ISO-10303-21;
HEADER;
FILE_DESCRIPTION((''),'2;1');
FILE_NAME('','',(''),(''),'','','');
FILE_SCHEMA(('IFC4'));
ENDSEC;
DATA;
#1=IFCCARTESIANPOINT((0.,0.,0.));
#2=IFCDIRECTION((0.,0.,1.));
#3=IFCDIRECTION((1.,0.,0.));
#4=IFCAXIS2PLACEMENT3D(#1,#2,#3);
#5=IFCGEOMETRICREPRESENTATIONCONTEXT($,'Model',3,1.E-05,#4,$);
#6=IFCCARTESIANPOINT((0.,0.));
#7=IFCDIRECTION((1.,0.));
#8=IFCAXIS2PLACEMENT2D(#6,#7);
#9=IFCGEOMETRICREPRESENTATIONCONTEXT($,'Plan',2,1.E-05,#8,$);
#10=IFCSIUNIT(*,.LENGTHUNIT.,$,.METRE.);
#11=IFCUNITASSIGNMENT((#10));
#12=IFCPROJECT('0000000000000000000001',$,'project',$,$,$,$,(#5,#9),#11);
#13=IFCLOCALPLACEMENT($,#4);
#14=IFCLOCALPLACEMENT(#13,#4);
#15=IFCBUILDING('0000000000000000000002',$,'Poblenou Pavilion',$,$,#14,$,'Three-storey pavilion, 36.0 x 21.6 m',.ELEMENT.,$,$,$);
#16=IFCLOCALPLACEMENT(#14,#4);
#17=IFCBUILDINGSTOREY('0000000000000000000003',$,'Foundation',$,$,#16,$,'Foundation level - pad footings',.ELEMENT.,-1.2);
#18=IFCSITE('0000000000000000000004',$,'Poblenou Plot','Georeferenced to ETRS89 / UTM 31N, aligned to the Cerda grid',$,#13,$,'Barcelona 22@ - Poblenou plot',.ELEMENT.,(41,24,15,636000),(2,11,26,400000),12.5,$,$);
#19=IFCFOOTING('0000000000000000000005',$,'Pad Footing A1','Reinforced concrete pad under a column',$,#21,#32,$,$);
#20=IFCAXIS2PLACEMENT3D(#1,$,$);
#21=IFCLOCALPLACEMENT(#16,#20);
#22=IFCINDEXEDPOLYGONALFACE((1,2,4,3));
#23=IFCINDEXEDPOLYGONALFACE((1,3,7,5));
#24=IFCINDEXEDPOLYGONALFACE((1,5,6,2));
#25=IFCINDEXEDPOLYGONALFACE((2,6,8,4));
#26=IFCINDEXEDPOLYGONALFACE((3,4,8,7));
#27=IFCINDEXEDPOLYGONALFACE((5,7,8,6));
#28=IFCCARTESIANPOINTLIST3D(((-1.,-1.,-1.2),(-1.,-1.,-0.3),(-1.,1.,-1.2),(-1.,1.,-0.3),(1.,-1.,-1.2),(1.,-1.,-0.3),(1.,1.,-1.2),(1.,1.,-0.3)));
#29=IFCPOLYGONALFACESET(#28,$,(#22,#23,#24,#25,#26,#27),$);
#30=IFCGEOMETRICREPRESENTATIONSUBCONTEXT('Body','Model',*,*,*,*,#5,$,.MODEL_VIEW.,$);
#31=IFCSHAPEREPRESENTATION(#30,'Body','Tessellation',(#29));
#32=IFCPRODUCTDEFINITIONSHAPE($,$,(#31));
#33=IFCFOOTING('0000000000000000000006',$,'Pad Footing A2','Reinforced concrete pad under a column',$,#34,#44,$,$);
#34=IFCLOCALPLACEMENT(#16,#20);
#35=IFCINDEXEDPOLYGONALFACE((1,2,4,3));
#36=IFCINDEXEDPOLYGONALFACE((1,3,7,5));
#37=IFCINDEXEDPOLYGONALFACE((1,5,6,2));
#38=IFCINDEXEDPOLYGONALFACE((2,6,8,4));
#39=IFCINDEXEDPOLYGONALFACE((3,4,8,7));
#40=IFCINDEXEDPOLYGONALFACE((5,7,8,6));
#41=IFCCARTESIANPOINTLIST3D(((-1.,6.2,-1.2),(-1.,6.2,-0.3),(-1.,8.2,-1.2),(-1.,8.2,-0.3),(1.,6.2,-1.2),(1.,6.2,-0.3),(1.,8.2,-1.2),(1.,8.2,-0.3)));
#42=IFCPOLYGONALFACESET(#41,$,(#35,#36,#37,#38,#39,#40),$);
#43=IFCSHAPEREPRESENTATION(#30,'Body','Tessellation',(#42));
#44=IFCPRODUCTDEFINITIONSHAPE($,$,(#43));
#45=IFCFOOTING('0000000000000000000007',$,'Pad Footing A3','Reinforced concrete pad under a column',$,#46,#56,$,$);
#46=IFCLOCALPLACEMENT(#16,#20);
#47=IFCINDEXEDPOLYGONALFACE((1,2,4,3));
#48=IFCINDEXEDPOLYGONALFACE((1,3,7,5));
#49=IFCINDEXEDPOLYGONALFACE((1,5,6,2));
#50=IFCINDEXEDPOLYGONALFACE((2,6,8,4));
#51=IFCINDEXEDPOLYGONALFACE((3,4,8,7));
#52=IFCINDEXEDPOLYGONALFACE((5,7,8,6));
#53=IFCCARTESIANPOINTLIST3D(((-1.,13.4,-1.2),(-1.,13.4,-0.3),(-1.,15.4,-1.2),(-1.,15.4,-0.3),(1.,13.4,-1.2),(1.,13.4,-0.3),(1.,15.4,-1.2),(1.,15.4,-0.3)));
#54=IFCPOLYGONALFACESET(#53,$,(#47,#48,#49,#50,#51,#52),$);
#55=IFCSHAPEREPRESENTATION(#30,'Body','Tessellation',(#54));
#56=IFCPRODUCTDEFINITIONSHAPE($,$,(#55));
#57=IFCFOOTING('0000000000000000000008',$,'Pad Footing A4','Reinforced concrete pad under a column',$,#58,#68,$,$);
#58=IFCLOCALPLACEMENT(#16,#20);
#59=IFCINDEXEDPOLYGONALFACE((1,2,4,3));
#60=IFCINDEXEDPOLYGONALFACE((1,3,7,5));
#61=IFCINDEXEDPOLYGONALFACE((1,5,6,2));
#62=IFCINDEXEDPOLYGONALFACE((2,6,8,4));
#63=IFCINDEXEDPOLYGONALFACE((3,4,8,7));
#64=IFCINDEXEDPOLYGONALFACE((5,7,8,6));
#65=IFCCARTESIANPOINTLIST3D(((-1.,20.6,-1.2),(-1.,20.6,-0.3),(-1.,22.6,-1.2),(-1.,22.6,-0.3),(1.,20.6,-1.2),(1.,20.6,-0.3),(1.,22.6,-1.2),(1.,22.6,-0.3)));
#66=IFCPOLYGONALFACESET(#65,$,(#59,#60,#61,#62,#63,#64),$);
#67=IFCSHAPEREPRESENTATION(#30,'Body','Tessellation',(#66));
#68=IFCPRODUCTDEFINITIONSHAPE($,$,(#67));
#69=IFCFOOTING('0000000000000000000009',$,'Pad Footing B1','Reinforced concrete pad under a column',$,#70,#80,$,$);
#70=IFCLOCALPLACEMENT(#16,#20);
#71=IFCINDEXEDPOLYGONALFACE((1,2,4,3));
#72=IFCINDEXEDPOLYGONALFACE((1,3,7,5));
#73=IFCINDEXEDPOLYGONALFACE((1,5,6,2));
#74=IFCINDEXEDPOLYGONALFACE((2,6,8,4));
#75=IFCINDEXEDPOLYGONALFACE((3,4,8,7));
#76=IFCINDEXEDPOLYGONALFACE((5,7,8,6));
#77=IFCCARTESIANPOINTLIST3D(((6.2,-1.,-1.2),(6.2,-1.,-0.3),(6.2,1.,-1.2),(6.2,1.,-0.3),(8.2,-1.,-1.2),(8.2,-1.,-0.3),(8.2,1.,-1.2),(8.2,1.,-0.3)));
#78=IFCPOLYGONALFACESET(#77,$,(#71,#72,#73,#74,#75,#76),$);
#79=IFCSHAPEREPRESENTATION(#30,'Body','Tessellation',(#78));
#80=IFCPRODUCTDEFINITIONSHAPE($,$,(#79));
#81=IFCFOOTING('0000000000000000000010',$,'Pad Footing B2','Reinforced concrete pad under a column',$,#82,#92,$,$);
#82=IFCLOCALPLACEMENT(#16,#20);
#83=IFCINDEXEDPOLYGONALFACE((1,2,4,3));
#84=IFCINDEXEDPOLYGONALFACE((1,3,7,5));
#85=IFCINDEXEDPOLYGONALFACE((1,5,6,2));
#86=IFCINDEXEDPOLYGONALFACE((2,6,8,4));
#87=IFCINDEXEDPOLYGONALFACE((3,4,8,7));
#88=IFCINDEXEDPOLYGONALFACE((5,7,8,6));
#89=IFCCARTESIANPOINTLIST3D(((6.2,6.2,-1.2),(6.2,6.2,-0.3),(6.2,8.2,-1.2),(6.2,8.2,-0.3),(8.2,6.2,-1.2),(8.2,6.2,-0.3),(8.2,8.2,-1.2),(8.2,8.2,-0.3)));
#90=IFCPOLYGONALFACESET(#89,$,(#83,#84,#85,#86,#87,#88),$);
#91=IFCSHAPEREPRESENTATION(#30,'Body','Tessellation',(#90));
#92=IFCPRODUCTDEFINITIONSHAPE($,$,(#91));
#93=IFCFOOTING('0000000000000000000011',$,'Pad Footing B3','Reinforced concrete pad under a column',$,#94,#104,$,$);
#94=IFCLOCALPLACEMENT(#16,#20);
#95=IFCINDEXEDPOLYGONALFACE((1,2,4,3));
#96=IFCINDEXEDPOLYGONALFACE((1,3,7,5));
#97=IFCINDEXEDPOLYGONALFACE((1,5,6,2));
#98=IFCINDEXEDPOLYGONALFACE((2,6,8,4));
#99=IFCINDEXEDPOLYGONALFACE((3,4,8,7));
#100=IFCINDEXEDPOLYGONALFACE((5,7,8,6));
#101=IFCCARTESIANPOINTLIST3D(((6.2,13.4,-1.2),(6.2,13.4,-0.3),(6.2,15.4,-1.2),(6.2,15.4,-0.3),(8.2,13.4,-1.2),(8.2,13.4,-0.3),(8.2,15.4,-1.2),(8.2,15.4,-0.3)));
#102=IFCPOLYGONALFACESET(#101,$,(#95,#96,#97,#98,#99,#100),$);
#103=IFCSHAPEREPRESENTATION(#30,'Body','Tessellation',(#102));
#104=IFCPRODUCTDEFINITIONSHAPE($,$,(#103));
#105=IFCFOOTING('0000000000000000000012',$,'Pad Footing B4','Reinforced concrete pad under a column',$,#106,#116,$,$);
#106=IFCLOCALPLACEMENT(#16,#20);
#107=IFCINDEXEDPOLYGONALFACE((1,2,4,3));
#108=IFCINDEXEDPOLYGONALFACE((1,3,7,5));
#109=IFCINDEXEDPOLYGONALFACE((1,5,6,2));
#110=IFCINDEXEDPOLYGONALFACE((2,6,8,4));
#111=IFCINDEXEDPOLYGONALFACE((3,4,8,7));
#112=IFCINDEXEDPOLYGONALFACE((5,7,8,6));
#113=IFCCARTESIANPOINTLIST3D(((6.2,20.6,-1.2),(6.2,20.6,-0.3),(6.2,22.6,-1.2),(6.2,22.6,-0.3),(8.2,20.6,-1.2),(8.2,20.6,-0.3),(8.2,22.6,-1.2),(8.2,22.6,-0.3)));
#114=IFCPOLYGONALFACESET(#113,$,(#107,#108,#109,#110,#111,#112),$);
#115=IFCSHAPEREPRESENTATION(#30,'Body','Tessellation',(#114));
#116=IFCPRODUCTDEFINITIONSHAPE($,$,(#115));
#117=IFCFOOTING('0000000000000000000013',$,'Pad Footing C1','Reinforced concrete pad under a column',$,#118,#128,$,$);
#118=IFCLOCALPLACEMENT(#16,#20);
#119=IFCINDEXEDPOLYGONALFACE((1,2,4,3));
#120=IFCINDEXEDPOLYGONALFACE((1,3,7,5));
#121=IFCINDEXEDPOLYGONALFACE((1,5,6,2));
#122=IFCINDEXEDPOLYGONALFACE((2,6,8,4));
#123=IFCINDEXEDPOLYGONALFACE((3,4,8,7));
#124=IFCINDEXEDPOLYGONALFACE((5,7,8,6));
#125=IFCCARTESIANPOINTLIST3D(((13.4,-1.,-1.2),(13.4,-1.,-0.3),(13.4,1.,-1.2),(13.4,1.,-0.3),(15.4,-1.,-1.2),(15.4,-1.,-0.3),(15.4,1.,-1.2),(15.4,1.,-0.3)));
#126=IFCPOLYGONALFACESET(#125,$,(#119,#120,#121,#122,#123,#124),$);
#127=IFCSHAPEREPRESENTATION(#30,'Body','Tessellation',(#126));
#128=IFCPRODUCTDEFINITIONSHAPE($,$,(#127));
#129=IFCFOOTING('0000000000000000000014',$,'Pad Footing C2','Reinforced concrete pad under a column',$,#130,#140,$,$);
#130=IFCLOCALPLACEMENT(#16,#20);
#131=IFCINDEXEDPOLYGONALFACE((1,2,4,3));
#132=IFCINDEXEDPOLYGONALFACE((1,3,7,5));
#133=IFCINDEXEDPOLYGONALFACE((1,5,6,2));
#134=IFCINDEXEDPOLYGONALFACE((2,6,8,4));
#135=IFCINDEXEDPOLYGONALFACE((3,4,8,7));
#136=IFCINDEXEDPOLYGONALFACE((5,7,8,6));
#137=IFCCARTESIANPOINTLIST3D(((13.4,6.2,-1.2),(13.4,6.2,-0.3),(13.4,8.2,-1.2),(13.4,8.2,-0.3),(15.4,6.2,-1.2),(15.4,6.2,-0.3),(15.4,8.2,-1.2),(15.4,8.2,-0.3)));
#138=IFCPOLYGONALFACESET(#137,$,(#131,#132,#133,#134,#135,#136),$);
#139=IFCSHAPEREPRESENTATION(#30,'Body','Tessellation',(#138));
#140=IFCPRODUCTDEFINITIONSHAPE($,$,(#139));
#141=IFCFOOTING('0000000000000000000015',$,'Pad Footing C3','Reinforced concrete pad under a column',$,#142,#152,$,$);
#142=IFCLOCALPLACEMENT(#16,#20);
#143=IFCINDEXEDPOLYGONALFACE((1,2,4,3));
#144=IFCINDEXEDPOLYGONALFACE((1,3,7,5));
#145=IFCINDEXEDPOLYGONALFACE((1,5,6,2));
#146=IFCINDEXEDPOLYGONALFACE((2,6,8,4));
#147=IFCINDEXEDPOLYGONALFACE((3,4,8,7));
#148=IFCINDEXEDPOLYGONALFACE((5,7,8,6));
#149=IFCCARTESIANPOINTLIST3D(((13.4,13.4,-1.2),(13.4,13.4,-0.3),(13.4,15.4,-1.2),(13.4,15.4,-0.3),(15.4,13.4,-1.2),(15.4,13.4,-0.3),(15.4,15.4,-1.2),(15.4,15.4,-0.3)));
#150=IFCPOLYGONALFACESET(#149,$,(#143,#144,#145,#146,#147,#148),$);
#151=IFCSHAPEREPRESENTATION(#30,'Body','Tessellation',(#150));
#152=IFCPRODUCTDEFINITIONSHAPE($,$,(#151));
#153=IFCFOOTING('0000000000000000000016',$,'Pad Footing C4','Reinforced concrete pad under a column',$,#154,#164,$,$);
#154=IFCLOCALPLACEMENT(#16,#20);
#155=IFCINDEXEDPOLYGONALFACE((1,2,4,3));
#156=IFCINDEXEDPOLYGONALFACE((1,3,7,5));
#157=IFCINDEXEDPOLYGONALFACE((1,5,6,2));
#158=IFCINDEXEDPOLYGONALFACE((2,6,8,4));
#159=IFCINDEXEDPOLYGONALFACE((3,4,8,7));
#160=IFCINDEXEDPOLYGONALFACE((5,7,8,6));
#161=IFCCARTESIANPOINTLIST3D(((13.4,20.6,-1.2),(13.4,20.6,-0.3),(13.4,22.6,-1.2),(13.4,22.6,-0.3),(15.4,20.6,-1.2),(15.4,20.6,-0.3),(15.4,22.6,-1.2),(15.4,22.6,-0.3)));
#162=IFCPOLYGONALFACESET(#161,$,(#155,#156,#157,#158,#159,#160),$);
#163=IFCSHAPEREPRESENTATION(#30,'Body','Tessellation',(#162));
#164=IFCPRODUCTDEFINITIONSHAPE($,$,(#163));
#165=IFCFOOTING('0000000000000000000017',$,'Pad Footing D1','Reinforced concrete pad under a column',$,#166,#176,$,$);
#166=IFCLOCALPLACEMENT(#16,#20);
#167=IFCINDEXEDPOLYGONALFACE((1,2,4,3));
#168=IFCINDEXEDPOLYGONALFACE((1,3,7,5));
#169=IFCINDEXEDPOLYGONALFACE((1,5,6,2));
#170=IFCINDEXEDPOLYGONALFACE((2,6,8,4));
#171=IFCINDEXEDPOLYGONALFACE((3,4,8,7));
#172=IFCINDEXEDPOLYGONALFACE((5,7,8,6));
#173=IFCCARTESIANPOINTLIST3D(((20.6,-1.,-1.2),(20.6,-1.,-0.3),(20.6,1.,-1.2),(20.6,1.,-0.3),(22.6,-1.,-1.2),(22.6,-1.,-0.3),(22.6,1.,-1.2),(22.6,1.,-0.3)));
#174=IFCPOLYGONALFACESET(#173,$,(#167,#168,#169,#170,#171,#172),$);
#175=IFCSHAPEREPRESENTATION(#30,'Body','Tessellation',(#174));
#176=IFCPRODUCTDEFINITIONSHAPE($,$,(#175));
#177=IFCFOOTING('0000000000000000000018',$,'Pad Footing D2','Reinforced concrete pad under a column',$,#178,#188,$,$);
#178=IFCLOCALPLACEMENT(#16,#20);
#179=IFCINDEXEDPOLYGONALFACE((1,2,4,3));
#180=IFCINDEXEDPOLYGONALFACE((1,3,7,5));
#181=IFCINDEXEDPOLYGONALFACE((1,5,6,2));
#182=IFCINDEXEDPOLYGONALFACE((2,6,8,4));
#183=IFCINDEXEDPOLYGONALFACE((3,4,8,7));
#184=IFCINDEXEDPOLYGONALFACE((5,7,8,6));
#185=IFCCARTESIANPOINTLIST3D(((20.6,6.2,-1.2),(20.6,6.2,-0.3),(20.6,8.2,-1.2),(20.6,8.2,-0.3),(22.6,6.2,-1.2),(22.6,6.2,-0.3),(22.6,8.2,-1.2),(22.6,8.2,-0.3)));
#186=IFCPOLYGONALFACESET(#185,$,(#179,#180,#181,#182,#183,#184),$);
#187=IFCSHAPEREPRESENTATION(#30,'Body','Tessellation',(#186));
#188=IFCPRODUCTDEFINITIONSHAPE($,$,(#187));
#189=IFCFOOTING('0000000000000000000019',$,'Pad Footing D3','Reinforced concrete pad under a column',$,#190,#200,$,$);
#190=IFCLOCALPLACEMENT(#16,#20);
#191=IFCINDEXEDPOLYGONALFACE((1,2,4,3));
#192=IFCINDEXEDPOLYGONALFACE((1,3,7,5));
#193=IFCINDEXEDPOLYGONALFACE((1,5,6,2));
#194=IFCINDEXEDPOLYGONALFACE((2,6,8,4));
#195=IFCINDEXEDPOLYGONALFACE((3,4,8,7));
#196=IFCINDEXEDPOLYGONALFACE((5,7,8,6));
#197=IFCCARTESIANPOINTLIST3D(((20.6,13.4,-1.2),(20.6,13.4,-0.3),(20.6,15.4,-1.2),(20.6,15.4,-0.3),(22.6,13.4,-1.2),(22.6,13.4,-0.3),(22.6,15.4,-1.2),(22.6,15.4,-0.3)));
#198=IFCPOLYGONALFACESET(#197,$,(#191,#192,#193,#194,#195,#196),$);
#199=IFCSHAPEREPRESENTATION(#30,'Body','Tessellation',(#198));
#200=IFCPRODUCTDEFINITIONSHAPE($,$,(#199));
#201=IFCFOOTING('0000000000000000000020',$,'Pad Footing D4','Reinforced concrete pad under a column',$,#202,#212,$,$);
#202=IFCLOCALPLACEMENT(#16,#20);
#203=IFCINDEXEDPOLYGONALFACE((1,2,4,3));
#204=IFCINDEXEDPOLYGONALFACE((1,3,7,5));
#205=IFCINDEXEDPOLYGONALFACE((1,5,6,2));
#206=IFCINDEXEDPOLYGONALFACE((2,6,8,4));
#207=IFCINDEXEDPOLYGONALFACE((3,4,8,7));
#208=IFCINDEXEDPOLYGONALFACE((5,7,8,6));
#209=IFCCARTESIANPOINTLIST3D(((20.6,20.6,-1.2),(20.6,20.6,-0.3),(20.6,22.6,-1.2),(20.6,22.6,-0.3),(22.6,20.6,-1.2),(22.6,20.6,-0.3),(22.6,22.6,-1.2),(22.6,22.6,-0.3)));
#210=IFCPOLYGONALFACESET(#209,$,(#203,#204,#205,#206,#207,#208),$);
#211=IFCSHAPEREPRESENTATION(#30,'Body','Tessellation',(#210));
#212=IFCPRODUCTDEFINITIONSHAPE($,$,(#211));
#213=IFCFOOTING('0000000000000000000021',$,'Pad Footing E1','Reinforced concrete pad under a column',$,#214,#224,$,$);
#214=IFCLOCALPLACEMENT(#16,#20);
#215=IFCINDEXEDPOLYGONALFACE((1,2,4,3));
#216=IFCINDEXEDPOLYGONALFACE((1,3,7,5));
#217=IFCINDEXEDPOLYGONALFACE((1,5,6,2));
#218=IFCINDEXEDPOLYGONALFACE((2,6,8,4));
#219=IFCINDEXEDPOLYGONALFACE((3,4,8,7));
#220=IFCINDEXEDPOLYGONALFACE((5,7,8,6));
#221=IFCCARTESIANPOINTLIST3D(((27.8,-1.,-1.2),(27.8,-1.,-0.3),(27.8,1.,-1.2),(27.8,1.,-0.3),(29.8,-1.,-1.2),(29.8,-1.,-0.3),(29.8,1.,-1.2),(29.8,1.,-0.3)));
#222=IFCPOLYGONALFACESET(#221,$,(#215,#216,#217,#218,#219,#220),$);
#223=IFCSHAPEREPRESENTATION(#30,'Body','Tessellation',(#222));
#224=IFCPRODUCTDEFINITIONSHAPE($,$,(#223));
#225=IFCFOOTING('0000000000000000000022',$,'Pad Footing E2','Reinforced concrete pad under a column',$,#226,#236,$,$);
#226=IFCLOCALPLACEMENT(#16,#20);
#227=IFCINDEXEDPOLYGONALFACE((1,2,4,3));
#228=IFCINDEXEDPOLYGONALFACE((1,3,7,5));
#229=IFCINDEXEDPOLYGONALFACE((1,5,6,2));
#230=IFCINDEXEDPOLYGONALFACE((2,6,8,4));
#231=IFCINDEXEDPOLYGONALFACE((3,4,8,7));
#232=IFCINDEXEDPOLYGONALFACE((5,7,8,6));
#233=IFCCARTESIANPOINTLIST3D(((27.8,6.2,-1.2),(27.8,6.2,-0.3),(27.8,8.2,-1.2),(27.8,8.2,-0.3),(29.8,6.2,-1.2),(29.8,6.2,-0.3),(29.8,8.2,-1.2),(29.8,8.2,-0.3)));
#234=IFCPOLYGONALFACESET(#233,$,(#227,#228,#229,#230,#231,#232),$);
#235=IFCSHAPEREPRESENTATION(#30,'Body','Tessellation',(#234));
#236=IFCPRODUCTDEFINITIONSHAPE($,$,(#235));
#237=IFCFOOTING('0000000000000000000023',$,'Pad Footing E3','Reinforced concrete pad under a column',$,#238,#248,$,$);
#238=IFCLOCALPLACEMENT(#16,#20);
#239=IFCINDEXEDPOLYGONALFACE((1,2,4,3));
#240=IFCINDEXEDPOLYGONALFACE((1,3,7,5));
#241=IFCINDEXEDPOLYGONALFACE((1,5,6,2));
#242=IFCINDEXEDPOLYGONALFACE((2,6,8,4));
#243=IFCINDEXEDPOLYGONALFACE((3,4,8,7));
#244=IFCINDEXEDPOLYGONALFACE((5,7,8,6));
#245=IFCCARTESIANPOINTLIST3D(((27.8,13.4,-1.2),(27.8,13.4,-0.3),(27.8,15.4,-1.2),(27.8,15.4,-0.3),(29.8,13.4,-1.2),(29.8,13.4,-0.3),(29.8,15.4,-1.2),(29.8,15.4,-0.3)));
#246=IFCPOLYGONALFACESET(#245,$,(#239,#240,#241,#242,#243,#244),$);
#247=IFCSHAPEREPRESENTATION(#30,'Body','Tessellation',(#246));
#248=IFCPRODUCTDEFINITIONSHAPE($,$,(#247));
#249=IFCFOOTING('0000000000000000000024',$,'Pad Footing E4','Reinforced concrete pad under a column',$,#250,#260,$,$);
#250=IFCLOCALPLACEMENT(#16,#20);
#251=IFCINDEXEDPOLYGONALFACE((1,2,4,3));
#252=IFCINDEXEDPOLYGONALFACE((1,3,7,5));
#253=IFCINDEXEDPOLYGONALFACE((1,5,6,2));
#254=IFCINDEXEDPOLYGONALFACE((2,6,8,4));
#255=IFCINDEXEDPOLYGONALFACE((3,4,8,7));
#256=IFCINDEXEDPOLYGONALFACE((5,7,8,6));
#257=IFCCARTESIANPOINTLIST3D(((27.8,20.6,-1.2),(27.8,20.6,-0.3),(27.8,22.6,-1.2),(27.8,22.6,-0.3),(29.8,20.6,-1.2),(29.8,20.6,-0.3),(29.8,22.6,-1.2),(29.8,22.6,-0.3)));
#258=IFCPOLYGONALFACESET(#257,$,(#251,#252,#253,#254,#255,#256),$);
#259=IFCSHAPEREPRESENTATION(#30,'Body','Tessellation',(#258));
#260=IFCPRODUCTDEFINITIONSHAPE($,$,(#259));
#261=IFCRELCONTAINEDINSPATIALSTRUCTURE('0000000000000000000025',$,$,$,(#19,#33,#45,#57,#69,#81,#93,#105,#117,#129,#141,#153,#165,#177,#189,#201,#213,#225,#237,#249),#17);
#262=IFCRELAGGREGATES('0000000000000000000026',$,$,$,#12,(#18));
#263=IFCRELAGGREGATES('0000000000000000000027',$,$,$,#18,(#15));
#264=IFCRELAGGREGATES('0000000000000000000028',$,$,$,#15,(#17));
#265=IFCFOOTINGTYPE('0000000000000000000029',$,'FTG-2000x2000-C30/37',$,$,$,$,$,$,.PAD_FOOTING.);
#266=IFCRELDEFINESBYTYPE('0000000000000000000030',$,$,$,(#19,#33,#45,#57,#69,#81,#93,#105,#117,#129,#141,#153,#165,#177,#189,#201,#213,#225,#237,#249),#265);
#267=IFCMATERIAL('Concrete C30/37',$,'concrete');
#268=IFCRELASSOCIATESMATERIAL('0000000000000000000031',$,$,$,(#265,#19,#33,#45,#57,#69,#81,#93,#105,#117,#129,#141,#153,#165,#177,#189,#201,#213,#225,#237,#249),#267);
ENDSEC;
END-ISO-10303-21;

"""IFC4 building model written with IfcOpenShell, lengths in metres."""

from ifc_helpers import new_model, si_unit, frame, origin_with_axes, origin_2d_with_axis, place, context, subcontext, project, spatial, line, indexed_curve, outline, extrude, material, type_object, element, save


model = new_model("IFC4")

# Units and contexts
model_context = context("Model", 3, precision=1e-05, world=origin_with_axes())
plan_context = context("Plan", 2, precision=1e-05, world=origin_2d_with_axis())
body_context = subcontext(model_context, "Body", "Model", "MODEL_VIEW")
ifc_project = project(units=[si_unit("LENGTHUNIT", "METRE")], contexts=[model_context, plan_context])

# Site, building, storey
site_placement = place(None, origin_with_axes())
site = spatial("IfcSite", under=ifc_project, at=site_placement, Name="Poblenou Plot", Description="Georeferenced to ETRS89 / UTM 31N, aligned to the Cerda grid", LongName="Barcelona 22@ - Poblenou plot", CompositionType="ELEMENT", RefLatitude=(41, 24, 15, 636000), RefLongitude=(2, 11, 26, 400000), RefElevation=12.5)
building_placement = place(site_placement, origin_with_axes())
building = spatial("IfcBuilding", under=site, at=building_placement, Name="Poblenou Pavilion", LongName="Three-storey pavilion, 36.0 x 21.6 m", CompositionType="ELEMENT")
storey_placement = place(building_placement, origin_with_axes())
storey = spatial("IfcBuildingStorey", under=building, at=storey_placement, Name="Foundation", LongName="Foundation level - pad footings", CompositionType="ELEMENT", Elevation=-1.2)

# Footings
ifc_material = material(Name="Concrete C30/37", Category="concrete")
footing_type = type_object("IfcFootingType", Name="FTG-2000x2000-C30/37", PredefinedType="PAD_FOOTING", material=ifc_material)
for number, where, z_axis, x_axis, name in (
    (1, (-1.0, -1.0, -1.2), (0.0, 0.0, 1.0), (1.0, 0.0, 0.0), "Pad Footing A1"),
    (2, (-1.0, 6.2, -1.2), (0.0, 0.0, 1.0), (1.0, 0.0, 0.0), "Pad Footing A2"),
    (3, (-1.0, 13.4, -1.2), (0.0, 0.0, 1.0), (1.0, 0.0, 0.0), "Pad Footing A3"),
    (4, (-1.0, 20.6, -1.2), (0.0, 0.0, 1.0), (1.0, 0.0, 0.0), "Pad Footing A4"),
    (5, (6.2, -1.0, -1.2), (0.0, 0.0, 1.0), (1.0, 0.0, 0.0), "Pad Footing B1"),
    (6, (6.2, 6.2, -1.2), (0.0, 0.0, 1.0), (1.0, 0.0, 0.0), "Pad Footing B2"),
    (7, (6.2, 13.4, -1.2), (0.0, 0.0, 1.0), (1.0, 0.0, 0.0), "Pad Footing B3"),
    (8, (6.2, 20.6, -1.2), (0.0, 0.0, 1.0), (1.0, 0.0, 0.0), "Pad Footing B4"),
    (9, (13.4, -1.0, -1.2), (0.0, 0.0, 1.0), (1.0, 0.0, 0.0), "Pad Footing C1"),
    (10, (13.4, 6.2, -1.2), (0.0, 0.0, 1.0), (1.0, 0.0, 0.0), "Pad Footing C2"),
    (11, (13.4, 13.4, -1.2), (0.0, 0.0, 1.0), (1.0, 0.0, 0.0), "Pad Footing C3"),
    (12, (13.4, 20.6, -1.2), (0.0, 0.0, 1.0), (1.0, 0.0, 0.0), "Pad Footing C4"),
    (13, (20.6, -1.0, -1.2), (0.0, 0.0, 1.0), (1.0, 0.0, 0.0), "Pad Footing D1"),
    (14, (20.6, 6.2, -1.2), (0.0, 0.0, 1.0), (1.0, 0.0, 0.0), "Pad Footing D2"),
    (15, (20.6, 13.4, -1.2), (0.0, 0.0, 1.0), (1.0, 0.0, 0.0), "Pad Footing D3"),
    (16, (20.6, 20.6, -1.2), (0.0, 0.0, 1.0), (1.0, 0.0, 0.0), "Pad Footing D4"),
    (17, (27.8, -1.0, -1.2), (0.0, 0.0, 1.0), (1.0, 0.0, 0.0), "Pad Footing E1"),
    (18, (27.8, 6.2, -1.2), (0.0, 0.0, 1.0), (1.0, 0.0, 0.0), "Pad Footing E2"),
    (19, (27.8, 13.4, -1.2), (0.0, 0.0, 1.0), (1.0, 0.0, 0.0), "Pad Footing E3"),
    (20, (27.8, 20.6, -1.2), (0.0, 0.0, 1.0), (1.0, 0.0, 0.0), "Pad Footing E4"),
):
    element("IfcFooting", number, at=place(storey_placement, frame(where, z_axis=z_axis, x_axis=x_axis)), inside=storey, type_object=footing_type, material=ifc_material, Name=name, Description="Reinforced concrete pad under a column", context=body_context, shape_type="SweptSolid", body=[
        extrude(outline(indexed_curve([(0.0, 0.0), (2.0, 0.0), (2.0, 2.0), (0.0, 2.0)], segments=[line(1, 2, 3, 4, 1)])), origin_with_axes(), (0.0, 0.0, 1.0), 0.9),
    ])

save(model, "model.ifc")
